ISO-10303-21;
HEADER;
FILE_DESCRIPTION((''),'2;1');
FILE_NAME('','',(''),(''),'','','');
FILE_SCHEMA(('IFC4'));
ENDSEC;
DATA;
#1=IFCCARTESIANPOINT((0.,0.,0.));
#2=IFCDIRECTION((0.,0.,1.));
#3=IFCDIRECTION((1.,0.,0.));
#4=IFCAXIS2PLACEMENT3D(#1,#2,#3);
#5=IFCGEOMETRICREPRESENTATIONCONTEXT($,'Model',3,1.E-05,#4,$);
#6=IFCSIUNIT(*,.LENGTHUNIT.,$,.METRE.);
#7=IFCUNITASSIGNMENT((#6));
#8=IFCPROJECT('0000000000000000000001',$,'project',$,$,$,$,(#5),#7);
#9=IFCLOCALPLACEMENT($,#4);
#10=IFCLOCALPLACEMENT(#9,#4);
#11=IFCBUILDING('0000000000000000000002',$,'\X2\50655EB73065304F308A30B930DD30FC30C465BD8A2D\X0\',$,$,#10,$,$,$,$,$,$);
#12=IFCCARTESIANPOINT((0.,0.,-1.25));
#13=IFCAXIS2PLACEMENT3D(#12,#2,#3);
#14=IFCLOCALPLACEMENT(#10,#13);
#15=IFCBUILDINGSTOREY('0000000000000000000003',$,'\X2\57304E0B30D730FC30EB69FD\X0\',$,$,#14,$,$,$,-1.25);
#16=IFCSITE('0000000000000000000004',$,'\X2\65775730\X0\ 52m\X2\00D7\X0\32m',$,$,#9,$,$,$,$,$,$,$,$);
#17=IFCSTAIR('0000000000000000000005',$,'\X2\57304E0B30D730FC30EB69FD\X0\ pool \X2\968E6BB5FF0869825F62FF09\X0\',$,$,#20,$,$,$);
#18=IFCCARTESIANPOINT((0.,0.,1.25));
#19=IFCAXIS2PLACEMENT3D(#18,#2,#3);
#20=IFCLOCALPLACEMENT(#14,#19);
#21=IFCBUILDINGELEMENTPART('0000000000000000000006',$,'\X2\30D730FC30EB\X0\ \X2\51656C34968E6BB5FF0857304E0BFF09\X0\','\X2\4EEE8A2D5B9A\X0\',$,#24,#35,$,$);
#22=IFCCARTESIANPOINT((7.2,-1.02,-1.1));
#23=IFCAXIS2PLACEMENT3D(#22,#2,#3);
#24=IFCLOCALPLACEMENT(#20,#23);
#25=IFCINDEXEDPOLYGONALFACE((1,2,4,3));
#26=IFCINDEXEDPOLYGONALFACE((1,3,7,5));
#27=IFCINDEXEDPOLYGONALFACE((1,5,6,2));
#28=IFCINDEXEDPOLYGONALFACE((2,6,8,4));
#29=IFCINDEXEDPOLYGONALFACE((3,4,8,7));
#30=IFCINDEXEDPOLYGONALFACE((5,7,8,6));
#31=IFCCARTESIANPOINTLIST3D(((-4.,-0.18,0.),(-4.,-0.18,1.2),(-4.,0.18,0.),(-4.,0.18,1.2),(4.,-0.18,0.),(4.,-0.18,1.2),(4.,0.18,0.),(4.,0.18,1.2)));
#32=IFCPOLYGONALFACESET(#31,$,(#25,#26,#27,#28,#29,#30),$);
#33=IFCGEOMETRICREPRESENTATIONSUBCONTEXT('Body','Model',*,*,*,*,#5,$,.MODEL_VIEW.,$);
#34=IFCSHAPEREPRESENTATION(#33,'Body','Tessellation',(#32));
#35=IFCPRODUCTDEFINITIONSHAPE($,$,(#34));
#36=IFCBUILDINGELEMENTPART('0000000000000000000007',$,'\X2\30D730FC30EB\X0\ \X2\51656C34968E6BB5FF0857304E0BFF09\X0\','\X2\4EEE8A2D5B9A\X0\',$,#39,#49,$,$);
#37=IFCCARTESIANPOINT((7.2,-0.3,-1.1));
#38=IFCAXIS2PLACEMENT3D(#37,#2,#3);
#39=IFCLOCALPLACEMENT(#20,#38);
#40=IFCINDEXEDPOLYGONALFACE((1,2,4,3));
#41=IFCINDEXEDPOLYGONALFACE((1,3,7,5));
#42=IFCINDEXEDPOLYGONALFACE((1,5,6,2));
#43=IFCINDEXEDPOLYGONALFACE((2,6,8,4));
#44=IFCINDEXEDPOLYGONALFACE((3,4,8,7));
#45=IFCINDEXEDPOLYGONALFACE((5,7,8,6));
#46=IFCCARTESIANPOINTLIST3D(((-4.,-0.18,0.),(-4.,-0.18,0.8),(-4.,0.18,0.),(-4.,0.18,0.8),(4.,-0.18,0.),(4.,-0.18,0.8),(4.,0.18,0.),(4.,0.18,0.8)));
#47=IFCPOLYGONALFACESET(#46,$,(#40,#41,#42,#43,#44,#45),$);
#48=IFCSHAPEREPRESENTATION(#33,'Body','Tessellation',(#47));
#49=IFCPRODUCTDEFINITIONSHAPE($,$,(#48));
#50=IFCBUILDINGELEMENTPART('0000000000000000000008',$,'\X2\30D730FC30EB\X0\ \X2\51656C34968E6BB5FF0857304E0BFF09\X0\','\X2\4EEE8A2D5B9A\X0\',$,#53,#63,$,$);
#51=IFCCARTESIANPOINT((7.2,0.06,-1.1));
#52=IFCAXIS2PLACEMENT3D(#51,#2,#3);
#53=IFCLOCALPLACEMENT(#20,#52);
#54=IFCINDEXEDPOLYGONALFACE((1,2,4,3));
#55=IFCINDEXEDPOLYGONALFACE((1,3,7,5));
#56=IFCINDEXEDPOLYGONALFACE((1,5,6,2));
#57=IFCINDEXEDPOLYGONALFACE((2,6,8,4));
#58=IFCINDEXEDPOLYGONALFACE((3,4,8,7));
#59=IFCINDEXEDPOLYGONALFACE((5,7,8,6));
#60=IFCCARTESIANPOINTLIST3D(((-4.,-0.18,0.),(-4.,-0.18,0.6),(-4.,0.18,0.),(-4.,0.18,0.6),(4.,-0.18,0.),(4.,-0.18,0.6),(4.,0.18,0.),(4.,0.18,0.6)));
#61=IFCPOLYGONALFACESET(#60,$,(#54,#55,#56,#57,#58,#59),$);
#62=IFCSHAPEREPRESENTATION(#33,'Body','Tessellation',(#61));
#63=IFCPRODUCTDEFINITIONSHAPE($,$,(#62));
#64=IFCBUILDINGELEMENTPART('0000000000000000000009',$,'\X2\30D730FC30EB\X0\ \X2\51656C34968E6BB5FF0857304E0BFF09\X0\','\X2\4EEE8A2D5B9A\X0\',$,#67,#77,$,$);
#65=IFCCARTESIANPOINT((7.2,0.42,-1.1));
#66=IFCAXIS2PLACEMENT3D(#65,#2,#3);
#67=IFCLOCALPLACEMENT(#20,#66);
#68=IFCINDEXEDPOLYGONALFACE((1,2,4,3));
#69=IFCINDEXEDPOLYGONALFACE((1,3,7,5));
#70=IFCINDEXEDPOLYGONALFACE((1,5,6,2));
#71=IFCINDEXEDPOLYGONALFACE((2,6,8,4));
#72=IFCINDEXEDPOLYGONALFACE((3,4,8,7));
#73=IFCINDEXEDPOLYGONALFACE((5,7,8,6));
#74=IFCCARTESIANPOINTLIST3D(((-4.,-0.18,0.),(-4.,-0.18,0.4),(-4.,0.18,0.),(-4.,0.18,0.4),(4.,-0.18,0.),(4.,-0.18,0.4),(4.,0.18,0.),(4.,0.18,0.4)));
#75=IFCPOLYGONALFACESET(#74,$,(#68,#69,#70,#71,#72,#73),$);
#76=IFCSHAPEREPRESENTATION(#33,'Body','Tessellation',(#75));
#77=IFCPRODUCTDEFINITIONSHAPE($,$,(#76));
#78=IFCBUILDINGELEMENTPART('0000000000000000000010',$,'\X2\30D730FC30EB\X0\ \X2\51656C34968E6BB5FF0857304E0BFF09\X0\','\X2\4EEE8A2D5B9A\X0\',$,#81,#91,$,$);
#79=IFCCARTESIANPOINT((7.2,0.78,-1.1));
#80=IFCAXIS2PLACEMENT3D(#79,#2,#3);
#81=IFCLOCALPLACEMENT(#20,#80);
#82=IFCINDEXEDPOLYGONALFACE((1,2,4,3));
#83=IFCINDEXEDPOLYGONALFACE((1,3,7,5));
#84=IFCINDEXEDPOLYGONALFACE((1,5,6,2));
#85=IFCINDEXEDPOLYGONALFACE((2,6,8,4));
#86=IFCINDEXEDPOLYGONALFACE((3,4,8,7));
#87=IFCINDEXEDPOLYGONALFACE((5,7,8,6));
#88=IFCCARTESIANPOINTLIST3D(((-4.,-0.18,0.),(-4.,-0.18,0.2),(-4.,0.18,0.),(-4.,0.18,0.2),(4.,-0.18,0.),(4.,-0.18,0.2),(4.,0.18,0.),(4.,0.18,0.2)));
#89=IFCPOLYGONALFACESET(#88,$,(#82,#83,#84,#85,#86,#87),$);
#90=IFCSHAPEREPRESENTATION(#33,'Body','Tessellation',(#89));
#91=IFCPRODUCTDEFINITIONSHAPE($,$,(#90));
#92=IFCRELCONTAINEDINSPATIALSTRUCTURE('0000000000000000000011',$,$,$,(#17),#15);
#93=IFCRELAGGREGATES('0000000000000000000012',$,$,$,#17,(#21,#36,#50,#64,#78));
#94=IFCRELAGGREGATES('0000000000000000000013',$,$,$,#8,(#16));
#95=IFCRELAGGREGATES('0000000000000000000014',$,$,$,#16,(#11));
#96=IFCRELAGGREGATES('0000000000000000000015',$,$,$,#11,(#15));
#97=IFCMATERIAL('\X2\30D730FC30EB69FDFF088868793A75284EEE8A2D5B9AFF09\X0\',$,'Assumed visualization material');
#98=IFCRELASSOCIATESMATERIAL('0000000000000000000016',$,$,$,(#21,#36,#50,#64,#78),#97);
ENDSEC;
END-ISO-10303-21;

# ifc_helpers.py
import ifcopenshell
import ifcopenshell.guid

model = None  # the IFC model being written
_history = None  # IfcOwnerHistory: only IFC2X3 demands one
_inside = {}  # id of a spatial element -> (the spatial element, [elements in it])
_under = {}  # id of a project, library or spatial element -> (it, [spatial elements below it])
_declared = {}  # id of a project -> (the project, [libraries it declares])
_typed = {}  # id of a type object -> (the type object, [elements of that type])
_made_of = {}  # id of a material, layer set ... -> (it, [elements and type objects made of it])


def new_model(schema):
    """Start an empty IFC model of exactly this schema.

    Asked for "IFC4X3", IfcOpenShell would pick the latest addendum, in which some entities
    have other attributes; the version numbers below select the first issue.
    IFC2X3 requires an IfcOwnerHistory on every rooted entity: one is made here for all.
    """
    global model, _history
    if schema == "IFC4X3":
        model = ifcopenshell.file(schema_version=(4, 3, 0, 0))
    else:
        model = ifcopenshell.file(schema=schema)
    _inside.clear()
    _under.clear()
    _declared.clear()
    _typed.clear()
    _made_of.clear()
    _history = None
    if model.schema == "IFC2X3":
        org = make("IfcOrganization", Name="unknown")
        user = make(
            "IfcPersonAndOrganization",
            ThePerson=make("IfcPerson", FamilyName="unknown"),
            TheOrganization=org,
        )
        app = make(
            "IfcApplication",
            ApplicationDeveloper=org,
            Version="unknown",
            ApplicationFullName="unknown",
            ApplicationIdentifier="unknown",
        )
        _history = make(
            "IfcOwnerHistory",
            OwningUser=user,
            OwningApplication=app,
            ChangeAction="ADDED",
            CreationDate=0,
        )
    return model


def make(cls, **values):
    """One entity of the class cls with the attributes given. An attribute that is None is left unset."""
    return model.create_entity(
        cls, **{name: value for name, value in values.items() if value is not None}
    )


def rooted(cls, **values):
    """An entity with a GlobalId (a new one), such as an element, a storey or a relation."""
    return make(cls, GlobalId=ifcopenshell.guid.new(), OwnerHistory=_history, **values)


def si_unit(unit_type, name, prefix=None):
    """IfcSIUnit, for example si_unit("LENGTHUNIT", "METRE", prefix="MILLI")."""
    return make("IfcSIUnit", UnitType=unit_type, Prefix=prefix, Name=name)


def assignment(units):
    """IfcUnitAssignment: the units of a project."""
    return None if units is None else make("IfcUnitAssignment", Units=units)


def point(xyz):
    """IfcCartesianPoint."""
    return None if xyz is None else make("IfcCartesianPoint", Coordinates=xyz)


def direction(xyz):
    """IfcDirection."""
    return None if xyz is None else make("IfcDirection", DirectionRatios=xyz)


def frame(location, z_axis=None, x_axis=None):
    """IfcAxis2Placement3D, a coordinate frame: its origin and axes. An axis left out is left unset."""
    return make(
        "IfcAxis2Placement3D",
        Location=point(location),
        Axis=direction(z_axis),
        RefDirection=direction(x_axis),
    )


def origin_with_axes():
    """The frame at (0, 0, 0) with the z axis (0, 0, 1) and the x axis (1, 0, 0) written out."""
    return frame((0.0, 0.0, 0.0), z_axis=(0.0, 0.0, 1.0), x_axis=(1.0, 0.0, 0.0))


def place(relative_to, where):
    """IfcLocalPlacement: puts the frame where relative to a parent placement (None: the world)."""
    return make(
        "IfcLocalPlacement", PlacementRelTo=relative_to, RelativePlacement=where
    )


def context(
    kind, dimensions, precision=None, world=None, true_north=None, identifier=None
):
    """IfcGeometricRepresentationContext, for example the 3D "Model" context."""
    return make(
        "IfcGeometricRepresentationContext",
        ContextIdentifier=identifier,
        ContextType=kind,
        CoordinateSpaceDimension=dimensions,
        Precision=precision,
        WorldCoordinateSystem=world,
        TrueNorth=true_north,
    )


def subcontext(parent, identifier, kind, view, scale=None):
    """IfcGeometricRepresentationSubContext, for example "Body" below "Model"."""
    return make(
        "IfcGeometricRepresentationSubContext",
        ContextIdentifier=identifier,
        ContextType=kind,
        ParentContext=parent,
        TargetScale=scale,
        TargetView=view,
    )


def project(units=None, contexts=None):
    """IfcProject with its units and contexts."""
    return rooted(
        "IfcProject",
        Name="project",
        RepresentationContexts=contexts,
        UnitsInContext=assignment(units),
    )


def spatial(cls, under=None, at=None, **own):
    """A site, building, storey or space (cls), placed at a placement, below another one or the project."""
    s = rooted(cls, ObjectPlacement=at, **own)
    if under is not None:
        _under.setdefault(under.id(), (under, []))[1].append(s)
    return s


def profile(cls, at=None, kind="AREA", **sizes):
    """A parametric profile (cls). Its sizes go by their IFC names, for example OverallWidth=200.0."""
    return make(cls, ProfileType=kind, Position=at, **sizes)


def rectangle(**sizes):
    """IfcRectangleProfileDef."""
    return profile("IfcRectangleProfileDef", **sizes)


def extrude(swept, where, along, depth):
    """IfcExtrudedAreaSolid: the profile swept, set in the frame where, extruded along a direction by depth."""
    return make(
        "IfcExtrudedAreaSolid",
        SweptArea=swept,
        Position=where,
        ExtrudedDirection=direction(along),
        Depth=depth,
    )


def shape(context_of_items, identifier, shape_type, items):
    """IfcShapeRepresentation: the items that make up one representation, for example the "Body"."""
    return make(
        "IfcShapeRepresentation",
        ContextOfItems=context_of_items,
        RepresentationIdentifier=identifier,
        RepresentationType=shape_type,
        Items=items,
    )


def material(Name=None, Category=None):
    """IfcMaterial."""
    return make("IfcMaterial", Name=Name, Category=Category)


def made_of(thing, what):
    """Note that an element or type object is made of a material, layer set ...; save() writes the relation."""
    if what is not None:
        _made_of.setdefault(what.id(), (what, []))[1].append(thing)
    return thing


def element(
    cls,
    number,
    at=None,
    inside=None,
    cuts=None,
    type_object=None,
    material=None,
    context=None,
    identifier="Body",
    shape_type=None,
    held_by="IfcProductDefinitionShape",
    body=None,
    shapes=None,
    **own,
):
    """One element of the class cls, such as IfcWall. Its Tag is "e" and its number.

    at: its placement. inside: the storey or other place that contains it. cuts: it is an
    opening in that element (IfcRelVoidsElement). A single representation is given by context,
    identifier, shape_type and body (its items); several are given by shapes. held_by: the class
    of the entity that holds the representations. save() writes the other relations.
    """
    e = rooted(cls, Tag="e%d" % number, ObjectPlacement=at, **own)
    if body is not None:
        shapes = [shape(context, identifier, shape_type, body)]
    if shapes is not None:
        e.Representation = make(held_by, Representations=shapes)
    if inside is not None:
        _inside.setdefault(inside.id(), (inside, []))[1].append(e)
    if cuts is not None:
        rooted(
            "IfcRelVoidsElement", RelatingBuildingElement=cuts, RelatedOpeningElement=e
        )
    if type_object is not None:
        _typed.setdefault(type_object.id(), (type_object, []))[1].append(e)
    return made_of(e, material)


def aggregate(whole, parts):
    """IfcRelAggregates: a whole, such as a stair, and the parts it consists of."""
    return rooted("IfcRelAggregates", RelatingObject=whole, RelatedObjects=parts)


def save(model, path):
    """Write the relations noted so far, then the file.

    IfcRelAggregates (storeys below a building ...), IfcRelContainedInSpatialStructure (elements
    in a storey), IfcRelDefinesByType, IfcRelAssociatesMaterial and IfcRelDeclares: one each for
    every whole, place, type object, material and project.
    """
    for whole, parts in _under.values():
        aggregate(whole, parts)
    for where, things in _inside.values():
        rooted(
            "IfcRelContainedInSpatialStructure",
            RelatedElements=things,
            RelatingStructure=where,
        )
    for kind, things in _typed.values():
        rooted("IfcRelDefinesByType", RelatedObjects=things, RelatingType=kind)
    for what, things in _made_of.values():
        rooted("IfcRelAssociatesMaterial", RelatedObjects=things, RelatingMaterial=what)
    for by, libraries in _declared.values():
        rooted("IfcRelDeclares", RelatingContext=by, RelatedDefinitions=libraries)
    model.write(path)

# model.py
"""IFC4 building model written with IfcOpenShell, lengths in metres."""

from ifc_helpers import new_model, si_unit, frame, origin_with_axes, place, context, subcontext, project, spatial, rectangle, extrude, material, element, aggregate, save


model = new_model("IFC4")

# Units and contexts
model_context = context("Model", 3, precision=1e-05, world=origin_with_axes())
body_context = subcontext(model_context, "Body", "Model", "MODEL_VIEW")
ifc_project = project(units=[si_unit("LENGTHUNIT", "METRE")], contexts=[model_context])

# Site, building, storey
site_placement = place(None, origin_with_axes())
site = spatial("IfcSite", under=ifc_project, at=site_placement, Name="敷地 52m×32m")
building_placement = place(site_placement, origin_with_axes())
building = spatial("IfcBuilding", under=site, at=building_placement, Name="健康づくりスポーツ施設")
storey_placement = place(building_placement, frame((0.0, 0.0, -1.25), z_axis=(0.0, 0.0, 1.0), x_axis=(1.0, 0.0, 0.0)))
storey = spatial("IfcBuildingStorey", under=building, at=storey_placement, Name="地下プール槽", Elevation=-1.25)

# Shared definitions
ifc_material = material(Name="プール槽（表示用仮設定）", Category="Assumed visualization material")

# Stair, building element parts
stair_placement = place(storey_placement, frame((0.0, 0.0, 1.25), z_axis=(0.0, 0.0, 1.0), x_axis=(1.0, 0.0, 0.0)))
stair = element("IfcStair", 1, at=stair_placement, inside=storey, Name="地下プール槽 pool 階段（概形）")
building_element_part_1_placement = place(stair_placement, frame((7.2, -1.02, -1.1), z_axis=(0.0, 0.0, 1.0), x_axis=(1.0, 0.0, 0.0)))
building_element_part_1 = element("IfcBuildingElementPart", 2, at=building_element_part_1_placement, material=ifc_material, Name="プール 入水階段（地下）", Description="仮設定", context=body_context, shape_type="SweptSolid", body=[
    extrude(rectangle(XDim=8.0, YDim=0.36), origin_with_axes(), (0.0, 0.0, 1.0), 1.2),
])
building_element_part_2_placement = place(stair_placement, frame((7.2, -0.3, -1.1), z_axis=(0.0, 0.0, 1.0), x_axis=(1.0, 0.0, 0.0)))
building_element_part_2 = element("IfcBuildingElementPart", 3, at=building_element_part_2_placement, material=ifc_material, Name="プール 入水階段（地下）", Description="仮設定", context=body_context, shape_type="SweptSolid", body=[
    extrude(rectangle(XDim=8.0, YDim=0.36), origin_with_axes(), (0.0, 0.0, 1.0), 0.8),
])
building_element_part_3_placement = place(stair_placement, frame((7.2, 0.06, -1.1), z_axis=(0.0, 0.0, 1.0), x_axis=(1.0, 0.0, 0.0)))
building_element_part_3 = element("IfcBuildingElementPart", 4, at=building_element_part_3_placement, material=ifc_material, Name="プール 入水階段（地下）", Description="仮設定", context=body_context, shape_type="SweptSolid", body=[
    extrude(rectangle(XDim=8.0, YDim=0.36), origin_with_axes(), (0.0, 0.0, 1.0), 0.6),
])
building_element_part_4_placement = place(stair_placement, frame((7.2, 0.42, -1.1), z_axis=(0.0, 0.0, 1.0), x_axis=(1.0, 0.0, 0.0)))
building_element_part_4 = element("IfcBuildingElementPart", 5, at=building_element_part_4_placement, material=ifc_material, Name="プール 入水階段（地下）", Description="仮設定", context=body_context, shape_type="SweptSolid", body=[
    extrude(rectangle(XDim=8.0, YDim=0.36), origin_with_axes(), (0.0, 0.0, 1.0), 0.4),
])
building_element_part_5_placement = place(stair_placement, frame((7.2, 0.78, -1.1), z_axis=(0.0, 0.0, 1.0), x_axis=(1.0, 0.0, 0.0)))
building_element_part_5 = element("IfcBuildingElementPart", 6, at=building_element_part_5_placement, material=ifc_material, Name="プール 入水階段（地下）", Description="仮設定", context=body_context, shape_type="SweptSolid", body=[
    extrude(rectangle(XDim=8.0, YDim=0.36), origin_with_axes(), (0.0, 0.0, 1.0), 0.2),
])
aggregate(stair, [building_element_part_1, building_element_part_2, building_element_part_3, building_element_part_4, building_element_part_5])

save(model, "model.ifc")
